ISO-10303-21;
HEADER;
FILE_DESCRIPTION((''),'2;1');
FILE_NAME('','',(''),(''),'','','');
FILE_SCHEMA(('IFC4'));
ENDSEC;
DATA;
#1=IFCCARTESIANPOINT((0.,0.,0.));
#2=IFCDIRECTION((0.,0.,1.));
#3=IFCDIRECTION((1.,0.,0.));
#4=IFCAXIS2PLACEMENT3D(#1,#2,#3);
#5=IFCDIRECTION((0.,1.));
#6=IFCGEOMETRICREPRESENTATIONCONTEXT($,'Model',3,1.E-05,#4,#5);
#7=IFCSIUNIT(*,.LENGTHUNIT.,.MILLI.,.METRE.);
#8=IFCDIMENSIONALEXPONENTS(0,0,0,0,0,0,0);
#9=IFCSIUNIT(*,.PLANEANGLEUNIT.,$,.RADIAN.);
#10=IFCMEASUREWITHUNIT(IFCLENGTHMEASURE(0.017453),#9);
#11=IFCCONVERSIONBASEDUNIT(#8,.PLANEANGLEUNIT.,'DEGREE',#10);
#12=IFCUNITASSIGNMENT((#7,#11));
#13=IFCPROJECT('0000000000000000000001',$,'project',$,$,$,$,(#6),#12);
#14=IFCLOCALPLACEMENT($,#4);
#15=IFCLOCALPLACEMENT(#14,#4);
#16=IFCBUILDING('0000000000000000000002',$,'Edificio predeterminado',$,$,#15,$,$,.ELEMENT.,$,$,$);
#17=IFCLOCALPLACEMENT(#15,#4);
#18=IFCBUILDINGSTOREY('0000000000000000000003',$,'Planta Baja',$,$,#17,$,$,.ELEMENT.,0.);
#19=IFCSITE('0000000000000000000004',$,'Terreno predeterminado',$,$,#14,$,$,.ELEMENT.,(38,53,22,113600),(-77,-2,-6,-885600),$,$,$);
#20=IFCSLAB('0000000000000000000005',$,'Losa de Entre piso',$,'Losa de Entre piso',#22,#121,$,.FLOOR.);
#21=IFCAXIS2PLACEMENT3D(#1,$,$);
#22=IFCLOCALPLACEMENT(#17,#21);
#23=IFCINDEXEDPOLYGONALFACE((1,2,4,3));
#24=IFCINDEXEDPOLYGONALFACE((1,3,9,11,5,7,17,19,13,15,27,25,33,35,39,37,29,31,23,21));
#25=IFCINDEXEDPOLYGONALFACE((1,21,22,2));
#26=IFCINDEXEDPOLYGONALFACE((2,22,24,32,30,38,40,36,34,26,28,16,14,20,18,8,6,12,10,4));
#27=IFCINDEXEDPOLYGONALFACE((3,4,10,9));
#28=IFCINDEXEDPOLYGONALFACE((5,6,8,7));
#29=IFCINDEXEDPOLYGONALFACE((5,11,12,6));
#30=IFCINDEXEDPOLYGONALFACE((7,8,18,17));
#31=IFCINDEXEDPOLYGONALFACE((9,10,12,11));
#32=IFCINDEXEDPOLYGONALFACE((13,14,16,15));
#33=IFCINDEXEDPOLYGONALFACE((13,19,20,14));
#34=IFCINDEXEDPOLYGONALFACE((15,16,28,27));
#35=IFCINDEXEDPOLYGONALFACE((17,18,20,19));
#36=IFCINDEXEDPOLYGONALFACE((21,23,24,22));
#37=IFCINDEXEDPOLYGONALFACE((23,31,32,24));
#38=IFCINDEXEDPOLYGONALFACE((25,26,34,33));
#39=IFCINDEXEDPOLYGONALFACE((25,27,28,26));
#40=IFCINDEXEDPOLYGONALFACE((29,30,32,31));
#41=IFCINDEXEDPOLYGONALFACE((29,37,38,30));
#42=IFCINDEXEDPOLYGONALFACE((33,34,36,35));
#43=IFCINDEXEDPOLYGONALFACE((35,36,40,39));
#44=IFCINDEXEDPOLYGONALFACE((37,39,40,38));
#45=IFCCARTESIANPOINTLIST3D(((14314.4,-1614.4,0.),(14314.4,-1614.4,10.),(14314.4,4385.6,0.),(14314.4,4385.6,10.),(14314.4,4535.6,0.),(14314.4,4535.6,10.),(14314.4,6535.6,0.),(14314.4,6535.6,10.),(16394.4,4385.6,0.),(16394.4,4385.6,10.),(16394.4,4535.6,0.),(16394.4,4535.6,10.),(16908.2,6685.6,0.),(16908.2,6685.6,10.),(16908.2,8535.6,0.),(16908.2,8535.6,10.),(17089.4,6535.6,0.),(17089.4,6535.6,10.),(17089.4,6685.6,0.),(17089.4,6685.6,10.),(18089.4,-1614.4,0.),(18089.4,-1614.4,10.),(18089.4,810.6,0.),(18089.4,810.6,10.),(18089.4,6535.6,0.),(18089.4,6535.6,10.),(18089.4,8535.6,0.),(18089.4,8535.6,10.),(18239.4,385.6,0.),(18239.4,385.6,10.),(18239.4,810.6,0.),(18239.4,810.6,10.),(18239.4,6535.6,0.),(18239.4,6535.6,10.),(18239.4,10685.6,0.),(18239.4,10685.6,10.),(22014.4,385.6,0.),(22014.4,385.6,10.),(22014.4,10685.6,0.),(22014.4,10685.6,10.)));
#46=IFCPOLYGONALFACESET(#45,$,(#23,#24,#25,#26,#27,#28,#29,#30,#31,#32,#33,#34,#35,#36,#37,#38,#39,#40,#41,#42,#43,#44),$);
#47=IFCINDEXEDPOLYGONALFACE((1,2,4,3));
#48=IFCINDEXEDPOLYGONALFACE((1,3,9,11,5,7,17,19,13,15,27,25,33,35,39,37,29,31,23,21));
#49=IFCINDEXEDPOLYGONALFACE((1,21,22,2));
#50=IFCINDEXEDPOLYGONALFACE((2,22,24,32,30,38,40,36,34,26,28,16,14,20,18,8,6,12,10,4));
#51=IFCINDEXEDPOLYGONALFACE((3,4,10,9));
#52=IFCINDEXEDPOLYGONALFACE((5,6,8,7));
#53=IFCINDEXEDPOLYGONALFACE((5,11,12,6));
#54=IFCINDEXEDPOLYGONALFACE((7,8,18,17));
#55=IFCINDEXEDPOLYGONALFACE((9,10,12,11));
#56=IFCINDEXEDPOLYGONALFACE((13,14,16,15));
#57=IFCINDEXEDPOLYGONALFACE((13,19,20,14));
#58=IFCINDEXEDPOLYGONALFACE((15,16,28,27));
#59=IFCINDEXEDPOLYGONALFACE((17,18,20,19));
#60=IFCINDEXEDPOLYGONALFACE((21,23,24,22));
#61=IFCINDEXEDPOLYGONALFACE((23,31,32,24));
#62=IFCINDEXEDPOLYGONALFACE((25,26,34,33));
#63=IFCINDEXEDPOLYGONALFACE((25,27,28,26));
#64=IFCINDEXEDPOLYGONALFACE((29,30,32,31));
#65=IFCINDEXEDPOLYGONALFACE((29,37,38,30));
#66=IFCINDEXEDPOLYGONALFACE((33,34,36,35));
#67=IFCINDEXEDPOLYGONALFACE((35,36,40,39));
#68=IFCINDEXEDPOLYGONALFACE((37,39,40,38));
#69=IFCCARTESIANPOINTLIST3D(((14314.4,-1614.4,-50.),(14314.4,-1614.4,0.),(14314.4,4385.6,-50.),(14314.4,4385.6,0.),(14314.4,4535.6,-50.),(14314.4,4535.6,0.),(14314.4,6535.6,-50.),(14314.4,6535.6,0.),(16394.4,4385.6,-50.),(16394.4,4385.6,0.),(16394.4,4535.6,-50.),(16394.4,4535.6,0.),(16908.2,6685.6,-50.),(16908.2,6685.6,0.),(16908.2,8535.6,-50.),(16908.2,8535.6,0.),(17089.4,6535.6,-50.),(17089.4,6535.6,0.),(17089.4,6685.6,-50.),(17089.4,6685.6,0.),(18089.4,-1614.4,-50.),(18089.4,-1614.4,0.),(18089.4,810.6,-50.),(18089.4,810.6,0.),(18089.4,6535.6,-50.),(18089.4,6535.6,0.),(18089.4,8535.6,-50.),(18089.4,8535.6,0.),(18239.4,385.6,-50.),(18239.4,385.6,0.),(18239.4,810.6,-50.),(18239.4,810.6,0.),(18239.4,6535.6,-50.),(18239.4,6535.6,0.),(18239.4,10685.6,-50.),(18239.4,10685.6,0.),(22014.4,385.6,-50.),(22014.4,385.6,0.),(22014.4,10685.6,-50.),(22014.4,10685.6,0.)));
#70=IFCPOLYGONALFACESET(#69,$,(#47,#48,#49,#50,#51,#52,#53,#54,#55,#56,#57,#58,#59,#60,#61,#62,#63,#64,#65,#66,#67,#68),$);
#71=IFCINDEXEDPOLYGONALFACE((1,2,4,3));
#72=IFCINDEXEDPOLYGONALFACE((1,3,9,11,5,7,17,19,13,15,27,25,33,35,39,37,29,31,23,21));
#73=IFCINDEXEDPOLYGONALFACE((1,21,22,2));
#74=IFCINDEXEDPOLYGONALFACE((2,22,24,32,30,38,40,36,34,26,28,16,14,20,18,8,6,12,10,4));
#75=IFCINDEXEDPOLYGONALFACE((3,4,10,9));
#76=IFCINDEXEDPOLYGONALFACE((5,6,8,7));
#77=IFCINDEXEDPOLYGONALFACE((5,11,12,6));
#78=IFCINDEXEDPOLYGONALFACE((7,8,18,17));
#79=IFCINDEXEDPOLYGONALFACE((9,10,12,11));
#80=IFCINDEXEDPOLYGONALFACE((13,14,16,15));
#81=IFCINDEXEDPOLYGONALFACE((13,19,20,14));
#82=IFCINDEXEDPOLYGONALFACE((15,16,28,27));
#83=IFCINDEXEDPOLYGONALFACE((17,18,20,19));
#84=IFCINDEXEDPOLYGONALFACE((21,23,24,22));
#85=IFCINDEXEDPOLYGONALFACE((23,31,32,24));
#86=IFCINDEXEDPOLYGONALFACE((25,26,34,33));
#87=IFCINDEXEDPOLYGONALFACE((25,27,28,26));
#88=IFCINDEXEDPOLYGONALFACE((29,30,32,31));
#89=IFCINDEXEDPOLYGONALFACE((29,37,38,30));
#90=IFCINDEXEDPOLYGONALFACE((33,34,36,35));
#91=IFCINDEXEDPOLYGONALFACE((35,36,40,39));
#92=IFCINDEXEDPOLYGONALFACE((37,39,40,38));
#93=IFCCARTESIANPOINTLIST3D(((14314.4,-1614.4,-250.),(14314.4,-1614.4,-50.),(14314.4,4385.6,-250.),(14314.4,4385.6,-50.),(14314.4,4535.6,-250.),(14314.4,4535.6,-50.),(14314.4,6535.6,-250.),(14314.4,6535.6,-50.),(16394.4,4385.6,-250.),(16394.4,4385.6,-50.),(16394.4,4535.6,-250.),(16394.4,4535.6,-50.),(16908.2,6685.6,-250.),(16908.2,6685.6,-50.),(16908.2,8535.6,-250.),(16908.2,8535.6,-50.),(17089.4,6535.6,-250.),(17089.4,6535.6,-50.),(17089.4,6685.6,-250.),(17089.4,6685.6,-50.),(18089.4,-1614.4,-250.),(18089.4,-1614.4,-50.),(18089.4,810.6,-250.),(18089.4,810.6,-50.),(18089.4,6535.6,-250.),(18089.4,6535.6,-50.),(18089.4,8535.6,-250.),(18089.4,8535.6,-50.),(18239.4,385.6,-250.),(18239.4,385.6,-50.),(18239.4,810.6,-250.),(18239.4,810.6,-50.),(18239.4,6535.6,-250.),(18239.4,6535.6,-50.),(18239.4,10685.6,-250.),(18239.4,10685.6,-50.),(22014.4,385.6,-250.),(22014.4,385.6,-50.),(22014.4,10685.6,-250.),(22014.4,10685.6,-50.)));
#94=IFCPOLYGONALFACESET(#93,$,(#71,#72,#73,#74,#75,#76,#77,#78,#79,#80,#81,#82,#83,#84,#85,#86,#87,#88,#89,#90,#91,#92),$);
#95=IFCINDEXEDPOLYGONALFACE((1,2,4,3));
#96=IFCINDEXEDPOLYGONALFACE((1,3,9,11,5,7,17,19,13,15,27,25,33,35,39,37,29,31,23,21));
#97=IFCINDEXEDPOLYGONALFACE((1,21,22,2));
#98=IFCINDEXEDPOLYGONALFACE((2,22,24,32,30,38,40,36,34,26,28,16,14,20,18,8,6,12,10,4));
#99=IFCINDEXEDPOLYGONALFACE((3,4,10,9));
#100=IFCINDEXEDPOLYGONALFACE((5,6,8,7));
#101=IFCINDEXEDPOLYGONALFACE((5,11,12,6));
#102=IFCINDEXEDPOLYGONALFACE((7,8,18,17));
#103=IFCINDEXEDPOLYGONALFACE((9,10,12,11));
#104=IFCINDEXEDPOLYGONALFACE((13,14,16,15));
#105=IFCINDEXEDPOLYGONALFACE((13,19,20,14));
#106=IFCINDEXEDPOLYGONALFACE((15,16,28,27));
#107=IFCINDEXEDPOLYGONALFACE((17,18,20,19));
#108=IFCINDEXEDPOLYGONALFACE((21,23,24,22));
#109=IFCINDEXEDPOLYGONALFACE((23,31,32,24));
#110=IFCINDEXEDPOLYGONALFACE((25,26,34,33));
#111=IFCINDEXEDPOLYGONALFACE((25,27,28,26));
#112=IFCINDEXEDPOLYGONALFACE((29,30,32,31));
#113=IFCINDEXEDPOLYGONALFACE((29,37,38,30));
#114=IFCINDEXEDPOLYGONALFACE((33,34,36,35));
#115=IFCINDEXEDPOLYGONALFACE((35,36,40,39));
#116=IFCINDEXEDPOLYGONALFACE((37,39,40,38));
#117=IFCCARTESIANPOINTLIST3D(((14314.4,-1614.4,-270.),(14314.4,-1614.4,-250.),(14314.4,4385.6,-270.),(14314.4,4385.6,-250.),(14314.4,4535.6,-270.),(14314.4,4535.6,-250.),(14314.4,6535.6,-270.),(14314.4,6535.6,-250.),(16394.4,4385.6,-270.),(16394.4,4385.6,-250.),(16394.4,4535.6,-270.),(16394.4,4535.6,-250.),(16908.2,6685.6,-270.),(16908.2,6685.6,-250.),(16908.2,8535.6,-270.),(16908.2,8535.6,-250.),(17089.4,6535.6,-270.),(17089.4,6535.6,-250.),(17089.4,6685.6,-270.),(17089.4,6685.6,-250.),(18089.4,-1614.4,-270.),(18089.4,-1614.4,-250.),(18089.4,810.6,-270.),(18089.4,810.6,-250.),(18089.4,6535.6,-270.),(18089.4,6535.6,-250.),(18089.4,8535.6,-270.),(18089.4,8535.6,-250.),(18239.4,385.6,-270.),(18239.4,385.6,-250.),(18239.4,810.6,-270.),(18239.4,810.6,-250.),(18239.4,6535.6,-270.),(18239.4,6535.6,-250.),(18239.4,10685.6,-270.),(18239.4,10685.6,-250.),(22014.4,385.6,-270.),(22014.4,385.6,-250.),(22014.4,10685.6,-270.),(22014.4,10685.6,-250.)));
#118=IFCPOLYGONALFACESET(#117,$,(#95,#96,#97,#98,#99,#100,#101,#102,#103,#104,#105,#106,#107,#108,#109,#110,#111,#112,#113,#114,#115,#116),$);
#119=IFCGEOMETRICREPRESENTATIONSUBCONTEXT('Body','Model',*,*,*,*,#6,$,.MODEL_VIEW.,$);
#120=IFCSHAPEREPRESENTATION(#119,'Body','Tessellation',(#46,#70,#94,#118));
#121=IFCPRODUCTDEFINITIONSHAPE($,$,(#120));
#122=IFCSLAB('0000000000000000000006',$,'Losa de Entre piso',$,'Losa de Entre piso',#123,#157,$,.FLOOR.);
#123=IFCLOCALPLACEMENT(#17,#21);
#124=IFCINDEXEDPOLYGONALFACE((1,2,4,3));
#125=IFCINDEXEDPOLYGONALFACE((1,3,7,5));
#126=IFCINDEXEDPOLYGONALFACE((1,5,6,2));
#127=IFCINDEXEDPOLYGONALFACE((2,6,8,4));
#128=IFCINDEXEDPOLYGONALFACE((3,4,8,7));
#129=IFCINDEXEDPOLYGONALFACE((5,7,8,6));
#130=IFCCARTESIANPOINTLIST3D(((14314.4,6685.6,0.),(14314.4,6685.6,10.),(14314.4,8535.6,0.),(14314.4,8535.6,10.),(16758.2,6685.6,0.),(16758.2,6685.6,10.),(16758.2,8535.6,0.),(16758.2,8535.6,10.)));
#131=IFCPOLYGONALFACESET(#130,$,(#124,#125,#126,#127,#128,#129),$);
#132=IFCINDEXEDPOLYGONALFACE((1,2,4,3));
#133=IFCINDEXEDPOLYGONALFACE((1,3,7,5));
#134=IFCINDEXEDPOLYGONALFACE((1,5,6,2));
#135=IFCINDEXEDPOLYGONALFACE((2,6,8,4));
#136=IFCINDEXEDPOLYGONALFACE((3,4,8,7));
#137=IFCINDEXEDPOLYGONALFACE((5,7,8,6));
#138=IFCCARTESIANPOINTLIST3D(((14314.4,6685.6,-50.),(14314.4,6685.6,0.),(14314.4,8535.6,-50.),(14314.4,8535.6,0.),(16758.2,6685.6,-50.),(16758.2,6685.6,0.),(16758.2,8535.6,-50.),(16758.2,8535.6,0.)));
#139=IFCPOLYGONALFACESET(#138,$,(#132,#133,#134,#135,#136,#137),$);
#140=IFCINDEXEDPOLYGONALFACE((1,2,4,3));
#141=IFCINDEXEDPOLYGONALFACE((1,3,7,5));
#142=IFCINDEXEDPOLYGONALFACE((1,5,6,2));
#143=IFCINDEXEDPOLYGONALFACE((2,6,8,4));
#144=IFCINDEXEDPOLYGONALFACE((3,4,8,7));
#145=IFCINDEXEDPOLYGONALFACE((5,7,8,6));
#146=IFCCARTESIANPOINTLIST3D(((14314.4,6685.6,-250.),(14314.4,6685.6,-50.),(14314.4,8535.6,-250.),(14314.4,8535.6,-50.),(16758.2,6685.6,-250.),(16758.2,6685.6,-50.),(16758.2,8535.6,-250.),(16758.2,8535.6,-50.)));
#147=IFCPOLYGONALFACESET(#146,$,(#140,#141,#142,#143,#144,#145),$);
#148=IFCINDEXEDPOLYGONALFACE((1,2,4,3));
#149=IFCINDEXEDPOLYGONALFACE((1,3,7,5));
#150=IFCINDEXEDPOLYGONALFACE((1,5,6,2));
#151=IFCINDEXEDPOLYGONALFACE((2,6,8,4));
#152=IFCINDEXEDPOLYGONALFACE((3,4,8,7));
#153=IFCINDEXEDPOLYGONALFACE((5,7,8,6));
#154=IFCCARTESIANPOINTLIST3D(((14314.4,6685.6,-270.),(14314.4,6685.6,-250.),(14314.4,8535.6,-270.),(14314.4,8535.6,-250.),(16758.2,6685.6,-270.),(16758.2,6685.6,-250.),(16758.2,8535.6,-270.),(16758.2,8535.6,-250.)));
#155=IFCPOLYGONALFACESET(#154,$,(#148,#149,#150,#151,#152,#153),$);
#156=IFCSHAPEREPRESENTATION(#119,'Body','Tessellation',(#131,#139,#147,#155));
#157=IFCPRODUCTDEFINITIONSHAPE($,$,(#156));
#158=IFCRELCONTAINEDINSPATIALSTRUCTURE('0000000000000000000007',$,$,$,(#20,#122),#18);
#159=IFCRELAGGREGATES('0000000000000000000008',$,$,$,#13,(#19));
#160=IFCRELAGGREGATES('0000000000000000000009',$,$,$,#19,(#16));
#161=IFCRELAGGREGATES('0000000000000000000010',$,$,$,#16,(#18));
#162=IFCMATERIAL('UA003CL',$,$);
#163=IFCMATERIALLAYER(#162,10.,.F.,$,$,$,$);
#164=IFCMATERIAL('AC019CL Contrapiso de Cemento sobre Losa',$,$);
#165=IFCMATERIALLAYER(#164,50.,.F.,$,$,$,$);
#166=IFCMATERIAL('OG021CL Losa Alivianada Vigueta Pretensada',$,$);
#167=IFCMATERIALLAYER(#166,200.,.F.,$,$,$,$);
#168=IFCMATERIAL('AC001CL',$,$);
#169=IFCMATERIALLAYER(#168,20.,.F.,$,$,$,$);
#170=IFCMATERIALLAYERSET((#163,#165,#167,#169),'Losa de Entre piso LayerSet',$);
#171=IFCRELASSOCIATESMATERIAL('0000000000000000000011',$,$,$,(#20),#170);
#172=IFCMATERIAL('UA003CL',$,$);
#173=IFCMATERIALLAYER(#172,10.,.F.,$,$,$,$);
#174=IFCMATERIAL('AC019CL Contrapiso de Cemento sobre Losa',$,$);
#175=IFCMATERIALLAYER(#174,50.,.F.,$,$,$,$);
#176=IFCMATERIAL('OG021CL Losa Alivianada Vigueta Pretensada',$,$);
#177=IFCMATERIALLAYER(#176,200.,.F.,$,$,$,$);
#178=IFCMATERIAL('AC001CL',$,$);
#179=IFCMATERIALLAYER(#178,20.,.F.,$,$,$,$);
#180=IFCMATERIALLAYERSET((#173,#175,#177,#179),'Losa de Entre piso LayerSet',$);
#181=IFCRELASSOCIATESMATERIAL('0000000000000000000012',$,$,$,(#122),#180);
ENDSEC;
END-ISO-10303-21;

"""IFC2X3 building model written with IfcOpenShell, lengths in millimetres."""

from ifc_helpers import new_model, entity, si_unit, converted_unit, direction, frame, origin_with_axes, place, context, subcontext, project, spatial, polyline, outline, extrude, material, layer, layer_set, layer_usage, element, save


model = new_model("IFC2X3")

# Units and contexts
model_context = context("Model", 3, precision=1e-05, world=origin_with_axes(), true_north=direction((0.0, 1.0)))
body_context = subcontext(model_context, "Body", "Model", "MODEL_VIEW")
ifc_project = project(units=[si_unit("LENGTHUNIT", "METRE", prefix="MILLI"), converted_unit("PLANEANGLEUNIT", "DEGREE", entity("IfcLengthMeasure", 0.017453), si_unit("PLANEANGLEUNIT", "RADIAN"), dimensions=[0, 0, 0, 0, 0, 0, 0])], contexts=[model_context])

# Site, building, storey
site_placement = place(None, origin_with_axes())
site = spatial("IfcSite", under=ifc_project, at=site_placement, Name="Terreno predeterminado", CompositionType="ELEMENT", RefLatitude=(38, 53, 22, 113600), RefLongitude=(-77, -2, -6, -885600))
building_placement = place(site_placement, origin_with_axes())
building = spatial("IfcBuilding", under=site, at=building_placement, Name="Edificio predeterminado", CompositionType="ELEMENT")
storey_placement = place(building_placement, origin_with_axes())
storey = spatial("IfcBuildingStorey", under=building, at=storey_placement, Name="Planta Baja", CompositionType="ELEMENT", Elevation=0.0)

# Slabs
ifc_material_1 = material(Name="UA003CL")
ifc_layer_1 = layer(ifc_material_1, 10.0, ventilated=False)
ifc_material_2 = material(Name="AC019CL Contrapiso de Cemento sobre Losa")
ifc_layer_2 = layer(ifc_material_2, 50.0, ventilated=False)
ifc_material_3 = material(Name="OG021CL Losa Alivianada Vigueta Pretensada")
ifc_layer_3 = layer(ifc_material_3, 200.0, ventilated=False)
ifc_material_4 = material(Name="AC001CL")
ifc_layer_4 = layer(ifc_material_4, 20.0, ventilated=False)
ifc_layer_set_1 = layer_set([ifc_layer_1, ifc_layer_2, ifc_layer_3, ifc_layer_4], Name="Losa de Entre piso LayerSet")
ifc_layer_usage_1 = layer_usage(ifc_layer_set_1, "AXIS3", "POSITIVE", 0.0)
slab_1_placement = place(storey_placement, origin_with_axes())
element("IfcSlab", 1, at=slab_1_placement, inside=storey, material=ifc_layer_usage_1, Name="Losa de Entre piso", ObjectType="Losa de Entre piso", PredefinedType="FLOOR", context=body_context, shape_type="SweptSolid", body=[
    extrude(outline(polyline([(0.0, -6000.0), (3775.0, -6000.0), (3775.0, -3575.0), (3925.0, -3575.0), (3925.0, -4000.0), (7700.0, -4000.0), (7700.0, 6300.0), (3925.0, 6300.0), (3925.0, 2150.0), (3775.0, 2150.0), (3775.0, 4150.0), (2593.9, 4150.0), (2593.9, 2300.0), (2775.0, 2300.0), (2775.0, 2150.0), (0.0, 2150.0), (0.0, 150.0), (2080.0, 150.0), (2080.0, 0.0), (0.0, 0.0), (0.0, -6000.0)])), frame((14314.4, 4385.6, 0.0), z_axis=(0.0, 0.0, 1.0), x_axis=(1.0, 0.0, 0.0)), (0.0, 0.0, 1.0), 10.0),
    extrude(outline(polyline([(0.0, -6000.0), (3775.0, -6000.0), (3775.0, -3575.0), (3925.0, -3575.0), (3925.0, -4000.0), (7700.0, -4000.0), (7700.0, 6300.0), (3925.0, 6300.0), (3925.0, 2150.0), (3775.0, 2150.0), (3775.0, 4150.0), (2593.9, 4150.0), (2593.9, 2300.0), (2775.0, 2300.0), (2775.0, 2150.0), (0.0, 2150.0), (0.0, 150.0), (2080.0, 150.0), (2080.0, 0.0), (0.0, 0.0), (0.0, -6000.0)])), frame((14314.4, 4385.6, -50.0), z_axis=(0.0, 0.0, 1.0), x_axis=(1.0, 0.0, 0.0)), (0.0, 0.0, 1.0), 50.0),
    extrude(outline(polyline([(0.0, -6000.0), (3775.0, -6000.0), (3775.0, -3575.0), (3925.0, -3575.0), (3925.0, -4000.0), (7700.0, -4000.0), (7700.0, 6300.0), (3925.0, 6300.0), (3925.0, 2150.0), (3775.0, 2150.0), (3775.0, 4150.0), (2593.9, 4150.0), (2593.9, 2300.0), (2775.0, 2300.0), (2775.0, 2150.0), (0.0, 2150.0), (0.0, 150.0), (2080.0, 150.0), (2080.0, 0.0), (0.0, 0.0), (0.0, -6000.0)])), frame((14314.4, 4385.6, -250.0), z_axis=(0.0, 0.0, 1.0), x_axis=(1.0, 0.0, 0.0)), (0.0, 0.0, 1.0), 200.0),
    extrude(outline(polyline([(0.0, -6000.0), (3775.0, -6000.0), (3775.0, -3575.0), (3925.0, -3575.0), (3925.0, -4000.0), (7700.0, -4000.0), (7700.0, 6300.0), (3925.0, 6300.0), (3925.0, 2150.0), (3775.0, 2150.0), (3775.0, 4150.0), (2593.9, 4150.0), (2593.9, 2300.0), (2775.0, 2300.0), (2775.0, 2150.0), (0.0, 2150.0), (0.0, 150.0), (2080.0, 150.0), (2080.0, 0.0), (0.0, 0.0), (0.0, -6000.0)])), frame((14314.4, 4385.6, -270.0), z_axis=(0.0, 0.0, 1.0), x_axis=(1.0, 0.0, 0.0)), (0.0, 0.0, 1.0), 20.0),
])
ifc_material_5 = material(Name="UA003CL")
ifc_layer_5 = layer(ifc_material_5, 10.0, ventilated=False)
ifc_material_6 = material(Name="AC019CL Contrapiso de Cemento sobre Losa")
ifc_layer_6 = layer(ifc_material_6, 50.0, ventilated=False)
ifc_material_7 = material(Name="OG021CL Losa Alivianada Vigueta Pretensada")
ifc_layer_7 = layer(ifc_material_7, 200.0, ventilated=False)
ifc_material_8 = material(Name="AC001CL")
ifc_layer_8 = layer(ifc_material_8, 20.0, ventilated=False)
ifc_layer_set_2 = layer_set([ifc_layer_5, ifc_layer_6, ifc_layer_7, ifc_layer_8], Name="Losa de Entre piso LayerSet")
ifc_layer_usage_2 = layer_usage(ifc_layer_set_2, "AXIS3", "NEGATIVE", 0.0)
slab_2_placement = place(storey_placement, origin_with_axes())
element("IfcSlab", 2, at=slab_2_placement, inside=storey, material=ifc_layer_usage_2, Name="Losa de Entre piso", ObjectType="Losa de Entre piso", PredefinedType="FLOOR", context=body_context, shape_type="SweptSolid", body=[
    extrude(outline(polyline([(0.0, 2443.9), (1850.0, 2443.9), (1850.0, 0.0), (0.0, 0.0), (0.0, 2443.9)])), frame((14314.4, 6685.6, 0.0), z_axis=(0.0, 0.0, -1.0), x_axis=(0.0, 1.0, 0.0)), (0.0, 0.0, -1.0), 10.0),
    extrude(outline(polyline([(0.0, 2443.9), (1850.0, 2443.9), (1850.0, 0.0), (0.0, 0.0), (0.0, 2443.9)])), frame((14314.4, 6685.6, -50.0), z_axis=(0.0, 0.0, -1.0), x_axis=(0.0, 1.0, 0.0)), (0.0, 0.0, -1.0), 50.0),
    extrude(outline(polyline([(0.0, 2443.9), (1850.0, 2443.9), (1850.0, 0.0), (0.0, 0.0), (0.0, 2443.9)])), frame((14314.4, 6685.6, -250.0), z_axis=(0.0, 0.0, -1.0), x_axis=(0.0, 1.0, 0.0)), (0.0, 0.0, -1.0), 200.0),
    extrude(outline(polyline([(0.0, 2443.9), (1850.0, 2443.9), (1850.0, 0.0), (0.0, 0.0), (0.0, 2443.9)])), frame((14314.4, 6685.6, -270.0), z_axis=(0.0, 0.0, -1.0), x_axis=(0.0, 1.0, 0.0)), (0.0, 0.0, -1.0), 20.0),
])

save(model, "model.ifc")
